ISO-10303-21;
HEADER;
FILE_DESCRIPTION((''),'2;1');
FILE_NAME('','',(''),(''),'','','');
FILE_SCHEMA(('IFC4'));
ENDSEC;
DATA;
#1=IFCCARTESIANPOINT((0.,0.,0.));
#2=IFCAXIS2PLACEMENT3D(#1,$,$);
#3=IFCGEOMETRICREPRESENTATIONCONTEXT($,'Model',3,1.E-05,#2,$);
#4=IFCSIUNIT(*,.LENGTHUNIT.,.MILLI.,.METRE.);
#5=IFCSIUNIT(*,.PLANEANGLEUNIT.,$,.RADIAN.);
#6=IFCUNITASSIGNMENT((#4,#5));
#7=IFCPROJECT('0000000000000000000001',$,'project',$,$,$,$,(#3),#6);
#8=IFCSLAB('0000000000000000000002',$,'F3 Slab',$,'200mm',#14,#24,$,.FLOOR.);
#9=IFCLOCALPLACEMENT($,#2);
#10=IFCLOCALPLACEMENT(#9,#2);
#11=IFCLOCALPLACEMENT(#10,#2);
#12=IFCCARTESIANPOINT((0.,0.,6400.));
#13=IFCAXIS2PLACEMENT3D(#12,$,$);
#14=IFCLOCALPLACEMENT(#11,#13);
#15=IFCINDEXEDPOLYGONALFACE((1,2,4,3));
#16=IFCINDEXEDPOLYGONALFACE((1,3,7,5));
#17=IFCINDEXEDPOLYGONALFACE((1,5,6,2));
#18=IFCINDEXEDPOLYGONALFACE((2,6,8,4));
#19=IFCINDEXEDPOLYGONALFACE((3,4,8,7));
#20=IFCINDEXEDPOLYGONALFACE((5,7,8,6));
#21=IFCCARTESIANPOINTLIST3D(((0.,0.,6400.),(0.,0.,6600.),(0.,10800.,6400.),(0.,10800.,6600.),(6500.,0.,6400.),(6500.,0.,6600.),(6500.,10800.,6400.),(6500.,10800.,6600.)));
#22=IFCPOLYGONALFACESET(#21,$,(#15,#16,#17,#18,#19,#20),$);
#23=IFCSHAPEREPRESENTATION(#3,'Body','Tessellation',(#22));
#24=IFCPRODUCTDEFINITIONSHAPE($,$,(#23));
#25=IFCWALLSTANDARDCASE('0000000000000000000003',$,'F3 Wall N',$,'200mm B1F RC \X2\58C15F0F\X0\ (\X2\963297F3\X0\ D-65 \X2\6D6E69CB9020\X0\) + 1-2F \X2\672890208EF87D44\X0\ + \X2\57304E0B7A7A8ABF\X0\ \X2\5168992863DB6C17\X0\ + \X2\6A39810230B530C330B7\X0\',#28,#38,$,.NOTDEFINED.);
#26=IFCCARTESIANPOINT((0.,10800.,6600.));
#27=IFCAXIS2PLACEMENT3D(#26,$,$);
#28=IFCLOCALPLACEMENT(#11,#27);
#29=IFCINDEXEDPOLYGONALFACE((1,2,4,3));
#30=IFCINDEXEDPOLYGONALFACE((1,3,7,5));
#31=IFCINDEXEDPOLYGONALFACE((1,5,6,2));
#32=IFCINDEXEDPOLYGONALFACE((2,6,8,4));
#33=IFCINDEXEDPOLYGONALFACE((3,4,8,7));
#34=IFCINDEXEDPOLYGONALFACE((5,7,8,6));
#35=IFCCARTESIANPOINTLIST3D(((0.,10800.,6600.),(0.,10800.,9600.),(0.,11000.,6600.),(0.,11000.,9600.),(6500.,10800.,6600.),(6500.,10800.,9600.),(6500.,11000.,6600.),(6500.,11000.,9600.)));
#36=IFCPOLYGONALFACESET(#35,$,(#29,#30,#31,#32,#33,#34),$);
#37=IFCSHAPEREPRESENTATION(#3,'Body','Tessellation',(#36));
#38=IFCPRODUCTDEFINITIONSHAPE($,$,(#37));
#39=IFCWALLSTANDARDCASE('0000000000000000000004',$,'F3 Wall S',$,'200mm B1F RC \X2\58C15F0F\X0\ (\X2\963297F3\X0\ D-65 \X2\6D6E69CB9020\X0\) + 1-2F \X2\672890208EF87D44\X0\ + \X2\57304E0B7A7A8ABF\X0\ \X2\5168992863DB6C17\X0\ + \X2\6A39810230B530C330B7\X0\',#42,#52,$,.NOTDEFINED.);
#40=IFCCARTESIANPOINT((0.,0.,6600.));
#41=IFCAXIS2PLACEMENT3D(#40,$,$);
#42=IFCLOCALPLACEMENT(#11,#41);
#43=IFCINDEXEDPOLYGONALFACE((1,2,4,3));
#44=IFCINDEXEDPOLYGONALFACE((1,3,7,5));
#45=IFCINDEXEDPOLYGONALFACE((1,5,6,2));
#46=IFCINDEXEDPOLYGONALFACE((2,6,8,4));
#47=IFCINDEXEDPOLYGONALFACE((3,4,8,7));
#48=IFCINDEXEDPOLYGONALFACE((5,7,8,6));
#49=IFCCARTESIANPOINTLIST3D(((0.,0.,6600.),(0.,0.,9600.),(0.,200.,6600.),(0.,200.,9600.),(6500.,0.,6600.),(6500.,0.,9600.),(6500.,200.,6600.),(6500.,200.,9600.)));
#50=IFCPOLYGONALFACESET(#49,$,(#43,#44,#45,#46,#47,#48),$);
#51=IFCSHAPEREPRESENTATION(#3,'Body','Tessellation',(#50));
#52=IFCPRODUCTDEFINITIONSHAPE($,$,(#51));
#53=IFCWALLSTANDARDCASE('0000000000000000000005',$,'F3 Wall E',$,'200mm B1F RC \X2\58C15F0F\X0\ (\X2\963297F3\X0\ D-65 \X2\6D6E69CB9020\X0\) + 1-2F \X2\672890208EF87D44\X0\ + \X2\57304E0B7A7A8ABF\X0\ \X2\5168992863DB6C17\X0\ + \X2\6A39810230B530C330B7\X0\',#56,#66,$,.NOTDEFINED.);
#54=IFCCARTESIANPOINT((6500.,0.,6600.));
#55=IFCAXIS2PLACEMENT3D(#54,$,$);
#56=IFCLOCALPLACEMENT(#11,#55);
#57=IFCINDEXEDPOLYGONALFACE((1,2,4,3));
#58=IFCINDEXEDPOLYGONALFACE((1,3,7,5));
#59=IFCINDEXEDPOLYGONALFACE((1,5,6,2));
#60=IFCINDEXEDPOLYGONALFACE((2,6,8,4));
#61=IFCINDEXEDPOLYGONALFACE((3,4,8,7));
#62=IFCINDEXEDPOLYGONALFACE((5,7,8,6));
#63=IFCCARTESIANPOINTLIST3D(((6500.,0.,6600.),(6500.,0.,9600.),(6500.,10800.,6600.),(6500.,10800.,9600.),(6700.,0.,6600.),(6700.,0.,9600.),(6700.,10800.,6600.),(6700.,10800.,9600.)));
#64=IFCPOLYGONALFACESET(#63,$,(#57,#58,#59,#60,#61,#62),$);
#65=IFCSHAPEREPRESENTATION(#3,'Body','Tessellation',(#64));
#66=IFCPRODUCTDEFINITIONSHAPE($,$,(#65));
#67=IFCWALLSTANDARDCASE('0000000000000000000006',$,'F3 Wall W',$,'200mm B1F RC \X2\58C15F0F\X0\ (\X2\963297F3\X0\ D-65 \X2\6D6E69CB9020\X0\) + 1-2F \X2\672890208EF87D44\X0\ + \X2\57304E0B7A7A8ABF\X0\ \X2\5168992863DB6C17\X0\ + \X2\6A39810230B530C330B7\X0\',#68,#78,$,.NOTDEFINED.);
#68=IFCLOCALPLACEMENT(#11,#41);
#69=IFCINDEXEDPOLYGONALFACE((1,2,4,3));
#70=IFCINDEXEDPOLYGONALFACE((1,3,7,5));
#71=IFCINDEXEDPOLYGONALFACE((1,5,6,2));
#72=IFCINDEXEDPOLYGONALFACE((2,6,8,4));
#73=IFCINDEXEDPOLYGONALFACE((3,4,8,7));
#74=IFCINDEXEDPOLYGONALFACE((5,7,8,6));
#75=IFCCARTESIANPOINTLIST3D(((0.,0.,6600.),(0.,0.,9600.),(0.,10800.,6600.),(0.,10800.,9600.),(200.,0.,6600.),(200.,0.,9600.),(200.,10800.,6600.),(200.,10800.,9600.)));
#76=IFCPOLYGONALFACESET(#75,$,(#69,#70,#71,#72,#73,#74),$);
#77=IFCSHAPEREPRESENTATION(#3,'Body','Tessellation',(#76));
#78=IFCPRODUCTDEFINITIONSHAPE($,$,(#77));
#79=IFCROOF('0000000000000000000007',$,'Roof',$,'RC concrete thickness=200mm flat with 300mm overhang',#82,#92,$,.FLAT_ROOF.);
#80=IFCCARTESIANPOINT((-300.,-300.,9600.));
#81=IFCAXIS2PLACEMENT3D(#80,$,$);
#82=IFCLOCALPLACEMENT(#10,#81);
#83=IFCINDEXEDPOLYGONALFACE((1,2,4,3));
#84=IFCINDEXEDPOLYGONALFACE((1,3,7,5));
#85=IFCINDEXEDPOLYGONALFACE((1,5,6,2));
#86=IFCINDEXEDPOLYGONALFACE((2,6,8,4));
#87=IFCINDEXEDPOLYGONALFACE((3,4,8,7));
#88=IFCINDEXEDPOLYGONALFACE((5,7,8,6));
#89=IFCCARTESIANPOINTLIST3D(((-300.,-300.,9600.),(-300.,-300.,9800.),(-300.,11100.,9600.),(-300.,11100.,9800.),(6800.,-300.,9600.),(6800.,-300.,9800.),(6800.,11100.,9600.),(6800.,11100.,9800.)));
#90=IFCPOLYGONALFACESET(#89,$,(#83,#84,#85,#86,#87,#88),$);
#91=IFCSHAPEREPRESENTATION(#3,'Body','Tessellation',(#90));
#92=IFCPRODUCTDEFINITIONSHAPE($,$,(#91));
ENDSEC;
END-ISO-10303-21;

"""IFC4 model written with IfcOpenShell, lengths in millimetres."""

from ifc_helpers import new_model, si_unit, frame, frame_2d, origin, place, context, project, rectangle, extrude, element, save


model = new_model("IFC4")

# Units and contexts
model_context = context("Model", 3, precision=1e-05, world=origin())
ifc_project = project(units=[si_unit("LENGTHUNIT", "METRE", prefix="MILLI"), si_unit("PLANEANGLEUNIT", "RADIAN")], contexts=[model_context])

# Slab
placement_1 = place(None, origin())
placement_2 = place(placement_1, origin())
placement_3 = place(placement_2, origin())
slab_placement = place(placement_3, frame((0.0, 0.0, 6400.0)))
element("IfcSlab", 1, at=slab_placement, Name="F3 Slab", ObjectType="200mm", PredefinedType="FLOOR", context=model_context, shape_type="SweptSolid", body=[
    extrude(rectangle(XDim=6500.0, YDim=10800.0, at=frame_2d((3250.0, 5400.0))), frame((0.0, 0.0, 6400.0)), (0.0, 0.0, 1.0), 200.0),
])

# Walls
wall_1_placement = place(placement_3, frame((0.0, 10800.0, 6600.0)))
element("IfcWallStandardCase", 2, at=wall_1_placement, Name="F3 Wall N", ObjectType="200mm B1F RC 壁式 (防音 D-65 浮構造) + 1-2F 木造軸組 + 地下空調 全館換気 + 樹脂サッシ", PredefinedType="NOTDEFINED", context=model_context, shape_type="SweptSolid", body=[
    extrude(rectangle(XDim=6500.0, YDim=200.0, at=frame_2d((3250.0, 100.0))), frame((0.0, 10800.0, 6600.0)), (0.0, 0.0, 1.0), 3000.0),
])
wall_2_placement = place(placement_3, frame((0.0, 0.0, 6600.0)))
element("IfcWallStandardCase", 3, at=wall_2_placement, Name="F3 Wall S", ObjectType="200mm B1F RC 壁式 (防音 D-65 浮構造) + 1-2F 木造軸組 + 地下空調 全館換気 + 樹脂サッシ", PredefinedType="NOTDEFINED", context=model_context, shape_type="SweptSolid", body=[
    extrude(rectangle(XDim=6500.0, YDim=200.0, at=frame_2d((3250.0, 100.0))), frame((0.0, 0.0, 6600.0)), (0.0, 0.0, 1.0), 3000.0),
])
wall_3_placement = place(placement_3, frame((6500.0, 0.0, 6600.0)))
element("IfcWallStandardCase", 4, at=wall_3_placement, Name="F3 Wall E", ObjectType="200mm B1F RC 壁式 (防音 D-65 浮構造) + 1-2F 木造軸組 + 地下空調 全館換気 + 樹脂サッシ", PredefinedType="NOTDEFINED", context=model_context, shape_type="SweptSolid", body=[
    extrude(rectangle(XDim=200.0, YDim=10800.0, at=frame_2d((100.0, 5400.0))), frame((6500.0, 0.0, 6600.0)), (0.0, 0.0, 1.0), 3000.0),
])
wall_4_placement = place(placement_3, frame((0.0, 0.0, 6600.0)))
element("IfcWallStandardCase", 5, at=wall_4_placement, Name="F3 Wall W", ObjectType="200mm B1F RC 壁式 (防音 D-65 浮構造) + 1-2F 木造軸組 + 地下空調 全館換気 + 樹脂サッシ", PredefinedType="NOTDEFINED", context=model_context, shape_type="SweptSolid", body=[
    extrude(rectangle(XDim=200.0, YDim=10800.0, at=frame_2d((100.0, 5400.0))), frame((0.0, 0.0, 6600.0)), (0.0, 0.0, 1.0), 3000.0),
])

# Roof
roof_placement = place(placement_2, frame((-300.0, -300.0, 9600.0)))
element("IfcRoof", 6, at=roof_placement, Name="Roof", ObjectType="RC concrete thickness=200mm flat with 300mm overhang", PredefinedType="FLAT_ROOF", context=model_context, shape_type="SweptSolid", body=[
    extrude(rectangle(XDim=7100.0, YDim=11400.0, at=frame_2d((3550.0, 5700.0))), frame((-300.0, -300.0, 9600.0)), (0.0, 0.0, 1.0), 200.0),
])

save(model, "model.ifc")
